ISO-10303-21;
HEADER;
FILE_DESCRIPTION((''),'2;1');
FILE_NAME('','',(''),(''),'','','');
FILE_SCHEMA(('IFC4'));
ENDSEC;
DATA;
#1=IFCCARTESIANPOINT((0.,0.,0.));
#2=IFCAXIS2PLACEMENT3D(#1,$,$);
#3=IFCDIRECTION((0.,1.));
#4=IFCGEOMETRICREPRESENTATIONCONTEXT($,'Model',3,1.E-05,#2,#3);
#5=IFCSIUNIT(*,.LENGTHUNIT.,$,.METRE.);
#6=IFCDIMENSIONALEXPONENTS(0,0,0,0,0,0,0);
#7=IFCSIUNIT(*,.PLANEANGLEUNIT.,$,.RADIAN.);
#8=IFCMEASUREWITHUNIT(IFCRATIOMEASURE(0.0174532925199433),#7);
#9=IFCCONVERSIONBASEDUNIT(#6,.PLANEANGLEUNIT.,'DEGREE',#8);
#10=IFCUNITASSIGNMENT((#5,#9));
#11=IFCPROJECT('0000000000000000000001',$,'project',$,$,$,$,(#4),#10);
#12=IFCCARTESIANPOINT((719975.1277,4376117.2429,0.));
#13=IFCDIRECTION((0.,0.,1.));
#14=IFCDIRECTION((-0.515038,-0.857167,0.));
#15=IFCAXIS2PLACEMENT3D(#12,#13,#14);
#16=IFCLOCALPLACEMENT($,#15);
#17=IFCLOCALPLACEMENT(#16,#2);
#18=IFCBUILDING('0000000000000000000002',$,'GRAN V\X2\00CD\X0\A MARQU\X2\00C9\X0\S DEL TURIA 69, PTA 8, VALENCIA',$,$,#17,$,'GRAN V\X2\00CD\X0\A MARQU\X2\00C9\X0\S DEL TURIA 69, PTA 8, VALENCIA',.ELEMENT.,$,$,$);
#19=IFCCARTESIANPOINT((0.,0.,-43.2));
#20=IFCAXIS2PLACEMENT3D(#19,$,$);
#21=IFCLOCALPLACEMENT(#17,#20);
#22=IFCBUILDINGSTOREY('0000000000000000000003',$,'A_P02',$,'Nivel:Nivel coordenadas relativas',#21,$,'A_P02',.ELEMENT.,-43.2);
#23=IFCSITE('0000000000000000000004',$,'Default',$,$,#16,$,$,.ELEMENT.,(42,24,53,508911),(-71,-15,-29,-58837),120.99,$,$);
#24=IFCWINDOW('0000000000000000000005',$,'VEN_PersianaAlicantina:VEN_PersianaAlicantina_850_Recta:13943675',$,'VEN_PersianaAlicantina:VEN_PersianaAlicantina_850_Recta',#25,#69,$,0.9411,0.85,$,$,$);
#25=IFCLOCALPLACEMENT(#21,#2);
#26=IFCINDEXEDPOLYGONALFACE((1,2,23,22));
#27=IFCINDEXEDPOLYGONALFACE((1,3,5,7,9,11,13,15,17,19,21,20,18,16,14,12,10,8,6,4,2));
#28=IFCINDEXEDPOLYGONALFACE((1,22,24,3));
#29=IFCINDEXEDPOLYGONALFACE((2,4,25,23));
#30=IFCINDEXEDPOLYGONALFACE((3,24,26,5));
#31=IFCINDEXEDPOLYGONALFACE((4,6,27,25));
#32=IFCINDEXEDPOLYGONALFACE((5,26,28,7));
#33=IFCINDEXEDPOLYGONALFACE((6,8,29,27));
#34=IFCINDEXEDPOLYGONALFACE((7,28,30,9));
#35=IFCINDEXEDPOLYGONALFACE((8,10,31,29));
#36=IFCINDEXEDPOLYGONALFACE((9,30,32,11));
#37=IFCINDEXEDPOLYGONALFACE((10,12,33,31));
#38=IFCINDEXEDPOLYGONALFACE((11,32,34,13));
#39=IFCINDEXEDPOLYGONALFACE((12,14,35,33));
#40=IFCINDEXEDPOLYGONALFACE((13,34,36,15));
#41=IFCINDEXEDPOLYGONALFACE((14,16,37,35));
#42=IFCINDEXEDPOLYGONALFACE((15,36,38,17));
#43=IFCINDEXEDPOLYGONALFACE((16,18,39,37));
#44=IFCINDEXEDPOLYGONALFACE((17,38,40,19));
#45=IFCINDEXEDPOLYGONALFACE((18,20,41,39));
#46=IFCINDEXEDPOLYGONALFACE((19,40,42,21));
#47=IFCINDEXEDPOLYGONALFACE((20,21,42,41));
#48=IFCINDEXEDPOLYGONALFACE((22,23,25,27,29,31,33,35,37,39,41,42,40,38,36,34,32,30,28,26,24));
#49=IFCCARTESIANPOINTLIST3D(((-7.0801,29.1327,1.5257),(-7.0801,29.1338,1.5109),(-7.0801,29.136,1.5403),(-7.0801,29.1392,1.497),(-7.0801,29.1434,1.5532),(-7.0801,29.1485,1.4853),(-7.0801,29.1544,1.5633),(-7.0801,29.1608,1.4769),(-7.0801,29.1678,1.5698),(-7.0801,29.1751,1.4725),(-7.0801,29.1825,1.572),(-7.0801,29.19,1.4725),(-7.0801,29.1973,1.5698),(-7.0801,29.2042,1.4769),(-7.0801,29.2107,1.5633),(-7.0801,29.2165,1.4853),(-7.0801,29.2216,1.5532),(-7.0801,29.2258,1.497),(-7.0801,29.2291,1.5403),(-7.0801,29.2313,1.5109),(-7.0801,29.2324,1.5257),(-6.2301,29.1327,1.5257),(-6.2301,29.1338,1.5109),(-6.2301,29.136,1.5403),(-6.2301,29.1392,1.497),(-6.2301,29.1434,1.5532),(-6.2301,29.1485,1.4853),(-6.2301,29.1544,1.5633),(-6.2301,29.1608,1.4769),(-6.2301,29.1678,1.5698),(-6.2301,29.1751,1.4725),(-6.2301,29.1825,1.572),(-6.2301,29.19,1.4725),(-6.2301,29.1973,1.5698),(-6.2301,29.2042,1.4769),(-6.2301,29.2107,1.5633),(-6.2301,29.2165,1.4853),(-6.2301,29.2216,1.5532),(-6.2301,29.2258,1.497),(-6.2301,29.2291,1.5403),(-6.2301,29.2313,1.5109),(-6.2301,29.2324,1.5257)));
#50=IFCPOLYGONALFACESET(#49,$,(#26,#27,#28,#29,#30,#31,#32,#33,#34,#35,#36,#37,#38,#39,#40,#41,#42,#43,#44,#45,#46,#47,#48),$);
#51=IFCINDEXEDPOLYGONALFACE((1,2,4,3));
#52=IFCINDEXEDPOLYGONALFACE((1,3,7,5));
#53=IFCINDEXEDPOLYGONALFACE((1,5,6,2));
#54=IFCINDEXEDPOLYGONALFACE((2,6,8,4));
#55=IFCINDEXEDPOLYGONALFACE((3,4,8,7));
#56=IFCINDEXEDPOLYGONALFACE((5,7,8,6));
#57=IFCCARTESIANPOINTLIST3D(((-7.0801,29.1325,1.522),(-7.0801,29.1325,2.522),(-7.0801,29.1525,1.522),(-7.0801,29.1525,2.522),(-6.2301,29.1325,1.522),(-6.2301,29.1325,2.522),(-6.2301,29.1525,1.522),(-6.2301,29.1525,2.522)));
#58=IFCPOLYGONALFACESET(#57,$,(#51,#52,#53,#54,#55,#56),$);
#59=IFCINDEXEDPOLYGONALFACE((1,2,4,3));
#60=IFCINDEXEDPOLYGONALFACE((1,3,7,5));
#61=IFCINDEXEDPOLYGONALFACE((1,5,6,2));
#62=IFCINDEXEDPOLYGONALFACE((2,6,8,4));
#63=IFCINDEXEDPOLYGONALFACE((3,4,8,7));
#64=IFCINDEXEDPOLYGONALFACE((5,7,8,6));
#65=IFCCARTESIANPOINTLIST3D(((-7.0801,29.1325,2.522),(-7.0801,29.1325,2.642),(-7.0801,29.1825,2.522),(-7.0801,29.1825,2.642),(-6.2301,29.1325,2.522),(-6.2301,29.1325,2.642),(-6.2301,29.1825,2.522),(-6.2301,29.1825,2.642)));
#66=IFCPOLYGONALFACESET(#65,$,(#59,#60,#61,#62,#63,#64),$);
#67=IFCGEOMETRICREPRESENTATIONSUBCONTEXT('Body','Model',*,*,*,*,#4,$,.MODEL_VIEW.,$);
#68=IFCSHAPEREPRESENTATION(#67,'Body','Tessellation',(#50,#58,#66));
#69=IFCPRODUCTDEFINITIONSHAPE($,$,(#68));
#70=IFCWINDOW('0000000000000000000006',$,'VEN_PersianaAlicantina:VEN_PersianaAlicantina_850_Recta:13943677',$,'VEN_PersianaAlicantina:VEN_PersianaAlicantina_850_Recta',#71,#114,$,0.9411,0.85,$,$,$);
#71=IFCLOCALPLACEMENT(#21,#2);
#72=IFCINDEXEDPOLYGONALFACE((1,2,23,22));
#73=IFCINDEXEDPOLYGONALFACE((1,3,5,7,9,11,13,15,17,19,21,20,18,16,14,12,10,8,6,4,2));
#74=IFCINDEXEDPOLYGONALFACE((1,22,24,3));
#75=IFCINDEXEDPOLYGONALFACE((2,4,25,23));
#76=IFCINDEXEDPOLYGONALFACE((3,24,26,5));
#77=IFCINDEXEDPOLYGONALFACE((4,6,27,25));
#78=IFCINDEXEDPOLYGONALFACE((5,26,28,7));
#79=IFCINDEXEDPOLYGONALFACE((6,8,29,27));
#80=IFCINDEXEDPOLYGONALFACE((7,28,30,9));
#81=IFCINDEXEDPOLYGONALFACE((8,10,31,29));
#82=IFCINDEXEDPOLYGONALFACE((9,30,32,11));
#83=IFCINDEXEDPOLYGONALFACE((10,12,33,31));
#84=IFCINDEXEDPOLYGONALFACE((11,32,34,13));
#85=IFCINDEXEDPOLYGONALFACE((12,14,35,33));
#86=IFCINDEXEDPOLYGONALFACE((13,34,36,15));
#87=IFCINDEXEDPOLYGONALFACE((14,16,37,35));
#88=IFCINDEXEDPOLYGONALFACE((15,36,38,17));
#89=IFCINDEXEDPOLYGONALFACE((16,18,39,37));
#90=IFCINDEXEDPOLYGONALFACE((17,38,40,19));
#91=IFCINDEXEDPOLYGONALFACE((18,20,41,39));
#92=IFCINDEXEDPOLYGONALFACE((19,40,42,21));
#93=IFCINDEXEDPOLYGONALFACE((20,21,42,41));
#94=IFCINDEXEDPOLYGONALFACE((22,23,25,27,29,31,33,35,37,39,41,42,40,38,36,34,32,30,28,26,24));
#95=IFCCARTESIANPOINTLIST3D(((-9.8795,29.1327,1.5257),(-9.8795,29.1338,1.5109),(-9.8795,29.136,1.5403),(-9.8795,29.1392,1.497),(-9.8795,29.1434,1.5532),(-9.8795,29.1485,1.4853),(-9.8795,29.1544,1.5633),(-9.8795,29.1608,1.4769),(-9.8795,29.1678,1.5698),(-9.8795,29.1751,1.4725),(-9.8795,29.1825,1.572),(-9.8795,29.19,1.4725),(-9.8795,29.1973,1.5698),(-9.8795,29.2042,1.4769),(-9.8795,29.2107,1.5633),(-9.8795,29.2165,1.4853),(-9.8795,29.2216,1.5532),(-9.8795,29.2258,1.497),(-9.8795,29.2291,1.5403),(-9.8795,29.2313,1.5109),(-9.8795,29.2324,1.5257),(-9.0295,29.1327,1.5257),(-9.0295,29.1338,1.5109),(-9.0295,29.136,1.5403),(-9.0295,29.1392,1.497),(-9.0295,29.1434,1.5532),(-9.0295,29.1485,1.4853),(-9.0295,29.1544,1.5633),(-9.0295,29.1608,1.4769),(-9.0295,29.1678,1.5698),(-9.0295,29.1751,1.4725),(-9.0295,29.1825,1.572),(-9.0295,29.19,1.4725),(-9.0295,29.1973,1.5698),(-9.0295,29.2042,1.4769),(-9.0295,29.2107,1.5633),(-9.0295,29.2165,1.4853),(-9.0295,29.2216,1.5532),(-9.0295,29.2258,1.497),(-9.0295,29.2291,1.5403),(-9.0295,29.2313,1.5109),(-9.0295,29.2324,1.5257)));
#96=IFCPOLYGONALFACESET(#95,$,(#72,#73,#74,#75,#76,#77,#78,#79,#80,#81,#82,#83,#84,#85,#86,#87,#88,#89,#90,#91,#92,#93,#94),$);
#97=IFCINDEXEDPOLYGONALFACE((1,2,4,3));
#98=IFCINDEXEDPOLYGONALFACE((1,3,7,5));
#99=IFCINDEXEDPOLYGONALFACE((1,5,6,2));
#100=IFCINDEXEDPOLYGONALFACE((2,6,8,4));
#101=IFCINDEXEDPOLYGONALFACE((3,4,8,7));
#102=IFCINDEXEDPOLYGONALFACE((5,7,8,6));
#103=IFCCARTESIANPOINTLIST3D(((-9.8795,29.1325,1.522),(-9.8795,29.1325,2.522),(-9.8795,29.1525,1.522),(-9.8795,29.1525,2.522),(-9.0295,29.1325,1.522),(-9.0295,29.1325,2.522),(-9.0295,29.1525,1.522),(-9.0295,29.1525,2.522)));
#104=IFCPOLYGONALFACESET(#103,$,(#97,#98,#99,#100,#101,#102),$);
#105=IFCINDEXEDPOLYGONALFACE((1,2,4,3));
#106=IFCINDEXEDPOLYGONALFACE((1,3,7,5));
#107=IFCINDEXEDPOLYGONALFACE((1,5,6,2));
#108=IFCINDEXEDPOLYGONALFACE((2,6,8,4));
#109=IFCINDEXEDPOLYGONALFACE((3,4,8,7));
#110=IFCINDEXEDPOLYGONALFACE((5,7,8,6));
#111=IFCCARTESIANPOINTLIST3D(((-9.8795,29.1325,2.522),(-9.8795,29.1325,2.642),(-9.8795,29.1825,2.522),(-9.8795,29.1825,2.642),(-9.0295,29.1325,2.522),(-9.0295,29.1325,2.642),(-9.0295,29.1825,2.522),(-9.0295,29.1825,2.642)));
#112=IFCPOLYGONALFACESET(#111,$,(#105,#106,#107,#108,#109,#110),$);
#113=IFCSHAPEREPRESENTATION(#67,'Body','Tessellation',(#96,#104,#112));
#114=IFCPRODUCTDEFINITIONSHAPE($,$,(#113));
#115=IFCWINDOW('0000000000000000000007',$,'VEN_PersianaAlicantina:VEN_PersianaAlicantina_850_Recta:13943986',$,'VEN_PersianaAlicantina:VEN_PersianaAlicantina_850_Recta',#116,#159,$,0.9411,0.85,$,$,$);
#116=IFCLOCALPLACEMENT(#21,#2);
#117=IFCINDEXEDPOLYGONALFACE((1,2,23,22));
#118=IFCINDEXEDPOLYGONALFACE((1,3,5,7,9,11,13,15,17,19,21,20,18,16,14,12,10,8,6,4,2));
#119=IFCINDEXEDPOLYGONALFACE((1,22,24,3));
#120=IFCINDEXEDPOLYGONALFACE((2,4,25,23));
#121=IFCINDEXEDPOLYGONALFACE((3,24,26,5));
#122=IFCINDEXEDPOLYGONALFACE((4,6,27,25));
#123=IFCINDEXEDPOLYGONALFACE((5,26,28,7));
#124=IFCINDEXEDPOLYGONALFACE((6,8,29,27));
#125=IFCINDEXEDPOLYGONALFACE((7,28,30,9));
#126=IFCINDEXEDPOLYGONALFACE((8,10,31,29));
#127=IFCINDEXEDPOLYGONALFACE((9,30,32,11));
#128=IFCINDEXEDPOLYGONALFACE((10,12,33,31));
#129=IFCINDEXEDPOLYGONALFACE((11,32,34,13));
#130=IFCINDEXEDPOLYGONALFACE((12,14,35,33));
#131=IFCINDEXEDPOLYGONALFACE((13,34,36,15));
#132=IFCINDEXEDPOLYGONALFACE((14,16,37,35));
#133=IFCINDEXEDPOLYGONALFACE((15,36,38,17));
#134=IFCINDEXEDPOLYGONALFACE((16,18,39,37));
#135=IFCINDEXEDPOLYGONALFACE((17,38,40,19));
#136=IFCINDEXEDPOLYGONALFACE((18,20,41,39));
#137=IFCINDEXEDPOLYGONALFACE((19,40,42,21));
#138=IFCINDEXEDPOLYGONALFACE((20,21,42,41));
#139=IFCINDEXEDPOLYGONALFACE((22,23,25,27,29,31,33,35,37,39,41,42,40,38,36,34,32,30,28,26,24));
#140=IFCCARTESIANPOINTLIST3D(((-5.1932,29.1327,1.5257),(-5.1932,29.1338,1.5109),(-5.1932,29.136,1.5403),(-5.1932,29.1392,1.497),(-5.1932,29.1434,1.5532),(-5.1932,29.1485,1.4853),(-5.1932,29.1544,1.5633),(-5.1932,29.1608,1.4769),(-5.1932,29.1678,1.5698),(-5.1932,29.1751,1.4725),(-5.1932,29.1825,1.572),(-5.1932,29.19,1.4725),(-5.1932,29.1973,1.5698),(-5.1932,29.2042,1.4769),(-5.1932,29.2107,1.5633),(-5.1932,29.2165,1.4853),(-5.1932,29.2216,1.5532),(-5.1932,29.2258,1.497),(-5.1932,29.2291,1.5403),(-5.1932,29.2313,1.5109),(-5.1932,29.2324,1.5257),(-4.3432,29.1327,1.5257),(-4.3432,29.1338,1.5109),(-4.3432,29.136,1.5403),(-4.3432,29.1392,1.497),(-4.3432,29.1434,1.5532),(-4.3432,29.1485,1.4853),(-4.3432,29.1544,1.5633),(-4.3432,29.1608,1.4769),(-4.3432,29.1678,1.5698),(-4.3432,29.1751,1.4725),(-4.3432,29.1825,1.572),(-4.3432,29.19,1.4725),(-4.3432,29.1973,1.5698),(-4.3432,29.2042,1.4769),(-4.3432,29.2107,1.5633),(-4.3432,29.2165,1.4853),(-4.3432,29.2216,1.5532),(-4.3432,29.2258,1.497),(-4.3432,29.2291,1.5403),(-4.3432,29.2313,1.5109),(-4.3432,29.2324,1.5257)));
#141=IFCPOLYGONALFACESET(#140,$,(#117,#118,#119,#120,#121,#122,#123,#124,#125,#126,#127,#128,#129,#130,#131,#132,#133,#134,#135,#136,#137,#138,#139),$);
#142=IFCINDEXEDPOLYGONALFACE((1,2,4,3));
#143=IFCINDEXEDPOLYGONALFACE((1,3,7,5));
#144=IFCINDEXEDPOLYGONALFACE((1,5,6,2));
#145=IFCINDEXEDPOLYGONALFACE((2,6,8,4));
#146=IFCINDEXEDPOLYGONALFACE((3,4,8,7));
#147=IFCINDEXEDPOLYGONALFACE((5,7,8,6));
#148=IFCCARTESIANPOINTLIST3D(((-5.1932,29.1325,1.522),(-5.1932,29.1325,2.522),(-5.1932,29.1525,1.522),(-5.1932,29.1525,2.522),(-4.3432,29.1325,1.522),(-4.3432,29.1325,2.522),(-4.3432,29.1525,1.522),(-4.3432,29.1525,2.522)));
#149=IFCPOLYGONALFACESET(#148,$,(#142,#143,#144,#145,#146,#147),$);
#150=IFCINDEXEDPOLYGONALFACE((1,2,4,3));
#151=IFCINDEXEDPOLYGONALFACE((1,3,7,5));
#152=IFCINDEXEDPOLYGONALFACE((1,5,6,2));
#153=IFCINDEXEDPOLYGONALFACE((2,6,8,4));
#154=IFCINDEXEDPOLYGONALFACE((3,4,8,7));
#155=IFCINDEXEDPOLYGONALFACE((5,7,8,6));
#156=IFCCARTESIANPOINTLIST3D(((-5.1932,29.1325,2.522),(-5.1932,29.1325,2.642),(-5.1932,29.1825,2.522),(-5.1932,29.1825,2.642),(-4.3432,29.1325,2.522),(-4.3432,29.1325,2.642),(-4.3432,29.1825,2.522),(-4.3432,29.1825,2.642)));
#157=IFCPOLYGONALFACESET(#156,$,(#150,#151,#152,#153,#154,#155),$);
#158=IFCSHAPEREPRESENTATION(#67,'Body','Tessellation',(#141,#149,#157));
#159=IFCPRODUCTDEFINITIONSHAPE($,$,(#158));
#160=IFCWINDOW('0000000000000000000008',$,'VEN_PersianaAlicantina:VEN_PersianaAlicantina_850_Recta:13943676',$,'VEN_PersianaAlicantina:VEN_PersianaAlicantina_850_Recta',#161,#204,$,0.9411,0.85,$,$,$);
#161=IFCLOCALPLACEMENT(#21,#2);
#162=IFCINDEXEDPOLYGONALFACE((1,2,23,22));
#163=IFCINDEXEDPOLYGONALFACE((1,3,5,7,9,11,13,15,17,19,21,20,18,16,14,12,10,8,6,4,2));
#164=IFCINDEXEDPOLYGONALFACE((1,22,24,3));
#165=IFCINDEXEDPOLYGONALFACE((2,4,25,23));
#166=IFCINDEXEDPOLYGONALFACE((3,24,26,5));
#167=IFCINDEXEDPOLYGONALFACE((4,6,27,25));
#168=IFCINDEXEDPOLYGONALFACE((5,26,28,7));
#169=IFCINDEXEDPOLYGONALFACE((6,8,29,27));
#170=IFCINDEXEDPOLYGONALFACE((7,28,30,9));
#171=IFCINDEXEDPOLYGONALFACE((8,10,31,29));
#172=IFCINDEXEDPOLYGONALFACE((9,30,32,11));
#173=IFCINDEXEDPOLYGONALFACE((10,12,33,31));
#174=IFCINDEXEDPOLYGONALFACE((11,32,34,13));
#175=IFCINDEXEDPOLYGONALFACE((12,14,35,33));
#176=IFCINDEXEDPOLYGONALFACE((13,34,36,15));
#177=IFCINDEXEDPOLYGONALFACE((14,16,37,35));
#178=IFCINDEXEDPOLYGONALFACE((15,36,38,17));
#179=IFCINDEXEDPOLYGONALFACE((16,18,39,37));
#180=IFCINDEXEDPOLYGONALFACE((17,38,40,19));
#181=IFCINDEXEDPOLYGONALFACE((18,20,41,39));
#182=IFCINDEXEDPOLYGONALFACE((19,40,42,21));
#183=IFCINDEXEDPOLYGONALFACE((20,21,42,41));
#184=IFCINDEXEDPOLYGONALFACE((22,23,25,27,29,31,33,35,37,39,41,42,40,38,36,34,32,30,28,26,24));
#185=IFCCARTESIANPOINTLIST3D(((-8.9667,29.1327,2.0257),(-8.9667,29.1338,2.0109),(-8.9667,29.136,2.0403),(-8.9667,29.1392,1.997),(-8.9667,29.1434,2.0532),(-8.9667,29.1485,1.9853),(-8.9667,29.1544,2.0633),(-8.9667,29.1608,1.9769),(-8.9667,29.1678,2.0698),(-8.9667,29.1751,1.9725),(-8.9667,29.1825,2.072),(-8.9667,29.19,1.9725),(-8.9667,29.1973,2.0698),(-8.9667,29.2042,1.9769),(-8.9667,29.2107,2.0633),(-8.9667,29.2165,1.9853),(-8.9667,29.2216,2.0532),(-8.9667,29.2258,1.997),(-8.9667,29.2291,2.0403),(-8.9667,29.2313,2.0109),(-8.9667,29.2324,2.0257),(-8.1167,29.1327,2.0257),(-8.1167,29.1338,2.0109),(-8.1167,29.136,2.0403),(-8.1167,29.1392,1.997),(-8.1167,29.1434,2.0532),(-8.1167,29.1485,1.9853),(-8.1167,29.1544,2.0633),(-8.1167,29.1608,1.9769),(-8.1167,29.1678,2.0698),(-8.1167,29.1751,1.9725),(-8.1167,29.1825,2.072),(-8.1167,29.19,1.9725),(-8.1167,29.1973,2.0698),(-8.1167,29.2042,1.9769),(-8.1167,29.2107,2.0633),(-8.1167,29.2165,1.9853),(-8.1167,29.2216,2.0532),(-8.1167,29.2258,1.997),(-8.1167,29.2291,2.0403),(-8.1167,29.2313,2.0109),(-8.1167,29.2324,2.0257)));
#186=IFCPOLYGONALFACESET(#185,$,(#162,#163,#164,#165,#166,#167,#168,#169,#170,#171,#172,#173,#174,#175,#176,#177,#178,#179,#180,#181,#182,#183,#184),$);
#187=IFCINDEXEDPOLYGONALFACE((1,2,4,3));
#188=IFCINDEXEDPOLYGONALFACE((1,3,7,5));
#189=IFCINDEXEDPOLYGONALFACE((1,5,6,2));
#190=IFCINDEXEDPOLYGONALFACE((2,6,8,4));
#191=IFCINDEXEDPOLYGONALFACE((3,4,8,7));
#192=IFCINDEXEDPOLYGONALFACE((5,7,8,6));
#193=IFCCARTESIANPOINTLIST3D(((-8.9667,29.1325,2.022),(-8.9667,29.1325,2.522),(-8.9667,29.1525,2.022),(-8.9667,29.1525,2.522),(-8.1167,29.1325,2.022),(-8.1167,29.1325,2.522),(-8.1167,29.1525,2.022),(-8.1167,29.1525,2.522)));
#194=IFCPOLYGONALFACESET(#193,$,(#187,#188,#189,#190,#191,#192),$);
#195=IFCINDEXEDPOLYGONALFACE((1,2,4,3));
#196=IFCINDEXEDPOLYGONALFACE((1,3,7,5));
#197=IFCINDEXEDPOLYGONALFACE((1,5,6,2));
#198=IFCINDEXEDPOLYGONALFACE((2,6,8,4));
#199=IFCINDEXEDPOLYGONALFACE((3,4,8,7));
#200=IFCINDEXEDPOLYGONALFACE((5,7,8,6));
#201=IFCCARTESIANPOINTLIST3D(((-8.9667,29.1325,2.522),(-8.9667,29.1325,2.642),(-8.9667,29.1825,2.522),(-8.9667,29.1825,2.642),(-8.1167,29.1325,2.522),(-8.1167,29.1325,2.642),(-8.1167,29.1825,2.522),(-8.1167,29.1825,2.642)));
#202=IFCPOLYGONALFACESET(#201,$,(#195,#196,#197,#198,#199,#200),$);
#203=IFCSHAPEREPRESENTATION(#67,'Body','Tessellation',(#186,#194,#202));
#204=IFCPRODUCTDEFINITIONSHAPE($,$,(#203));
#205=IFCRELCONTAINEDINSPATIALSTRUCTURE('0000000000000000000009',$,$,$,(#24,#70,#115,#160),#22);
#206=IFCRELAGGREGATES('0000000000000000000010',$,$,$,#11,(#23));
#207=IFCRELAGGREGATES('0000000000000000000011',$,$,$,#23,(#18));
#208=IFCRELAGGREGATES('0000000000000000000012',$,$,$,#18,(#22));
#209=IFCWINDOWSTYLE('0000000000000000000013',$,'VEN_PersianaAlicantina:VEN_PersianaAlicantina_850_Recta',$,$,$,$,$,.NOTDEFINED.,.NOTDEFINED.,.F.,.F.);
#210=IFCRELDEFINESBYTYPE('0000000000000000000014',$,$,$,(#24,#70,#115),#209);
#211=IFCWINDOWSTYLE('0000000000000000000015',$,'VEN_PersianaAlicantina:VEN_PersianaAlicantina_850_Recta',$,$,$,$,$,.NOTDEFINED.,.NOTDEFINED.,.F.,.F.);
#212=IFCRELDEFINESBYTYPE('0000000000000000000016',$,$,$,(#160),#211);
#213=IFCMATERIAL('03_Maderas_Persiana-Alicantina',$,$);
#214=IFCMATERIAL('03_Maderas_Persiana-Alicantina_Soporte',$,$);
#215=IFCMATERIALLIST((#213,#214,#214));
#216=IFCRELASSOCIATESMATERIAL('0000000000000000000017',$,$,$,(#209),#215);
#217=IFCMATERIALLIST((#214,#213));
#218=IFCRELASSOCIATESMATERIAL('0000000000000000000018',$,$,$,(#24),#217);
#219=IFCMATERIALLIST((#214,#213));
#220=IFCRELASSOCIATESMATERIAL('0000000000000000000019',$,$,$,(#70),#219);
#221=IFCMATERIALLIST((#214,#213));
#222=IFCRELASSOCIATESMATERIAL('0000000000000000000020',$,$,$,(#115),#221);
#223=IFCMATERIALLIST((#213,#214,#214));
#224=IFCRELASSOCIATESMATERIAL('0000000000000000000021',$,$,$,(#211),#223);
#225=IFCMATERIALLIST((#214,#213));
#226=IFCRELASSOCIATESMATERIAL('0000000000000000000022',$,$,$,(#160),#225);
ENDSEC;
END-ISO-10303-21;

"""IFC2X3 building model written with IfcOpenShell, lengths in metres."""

from ifc_helpers import new_model, entity, si_unit, converted_unit, direction, frame, frame_2d, origin, origin_2d_with_axis, place, context, subcontext, project, spatial, rectangle, circle, extrude, source, transform, mapped, material, material_list, type_object, type_shapes, element, save


model = new_model("IFC2X3")

# Units and contexts
model_context = context("Model", 3, precision=1e-05, world=origin(), true_north=direction((0.0, 1.0)))
body_context = subcontext(model_context, "Body", "Model", "MODEL_VIEW")
ifc_project = project(units=[si_unit("LENGTHUNIT", "METRE"), converted_unit("PLANEANGLEUNIT", "DEGREE", entity("IfcRatioMeasure", 0.0174532925199433), si_unit("PLANEANGLEUNIT", "RADIAN"), dimensions=[0, 0, 0, 0, 0, 0, 0])], contexts=[model_context])

# Site, building, storey
site_placement = place(None, frame((719975.1277, 4376117.2429, 0.0), z_axis=(0.0, 0.0, 1.0), x_axis=(-0.515038, -0.857167, 0.0)))
site = spatial("IfcSite", under=ifc_project, at=site_placement, Name="Default", CompositionType="ELEMENT", RefLatitude=(42, 24, 53, 508911), RefLongitude=(-71, -15, -29, -58837), RefElevation=120.99)
building_placement = place(site_placement, origin())
building = spatial("IfcBuilding", under=site, at=building_placement, Name="GRAN VÍA MARQUÉS DEL TURIA 69, PTA 8, VALENCIA", LongName="GRAN VÍA MARQUÉS DEL TURIA 69, PTA 8, VALENCIA", CompositionType="ELEMENT")
storey_placement = place(building_placement, frame((0.0, 0.0, -43.2)))
storey = spatial("IfcBuildingStorey", under=building, at=storey_placement, Name="A_P02", ObjectType="Nivel:Nivel coordenadas relativas", LongName="A_P02", CompositionType="ELEMENT", Elevation=-43.2)

# Windows
ifc_material_1 = material(Name="03_Maderas_Persiana-Alicantina_Soporte")
ifc_material_2 = material(Name="03_Maderas_Persiana-Alicantina")
ifc_material_list_1 = material_list([ifc_material_1, ifc_material_2])
ifc_material_list_2 = material_list([ifc_material_2, ifc_material_1, ifc_material_1])
window_style_1 = type_object("IfcWindowStyle", Name="VEN_PersianaAlicantina:VEN_PersianaAlicantina_850_Recta", ConstructionType="NOTDEFINED", OperationType="NOTDEFINED", ParameterTakesPrecedence=False, Sizeable=False, material=ifc_material_list_2)
shared_shape_1 = source(origin(), body_context, "Body", "SweptSolid", [
    extrude(circle(Radius=0.05, at=frame_2d((0.0, 0.0), x_axis=(1.0, 0.0))), frame((-0.425, -0.5392, 0.05), z_axis=(1.0, 0.0, 0.0), x_axis=(0.0, 1.0, 0.0)), (0.0, 0.0, 1.0), 0.85),
    extrude(rectangle(XDim=0.85, YDim=1.0, at=frame_2d((0.0, 0.0), x_axis=(1.0, 0.0))), frame((0.0, -0.0392, 0.0), z_axis=(0.0, 0.0, 1.0), x_axis=(-1.0, 0.0, 0.0)), (0.0, 0.0, 1.0), 0.02),
    extrude(rectangle(XDim=0.85, YDim=0.12, at=frame_2d((0.0, 0.0), x_axis=(1.0, 0.0))), frame((0.0, 0.5208, 0.0), z_axis=(0.0, 0.0, 1.0), x_axis=(-1.0, 0.0, 0.0)), (0.0, 0.0, 1.0), 0.05),
])
type_shapes(window_style_1, [shared_shape_1])
window_1_placement = place(storey_placement, frame((-6.6551, 29.1325, 2.0612), z_axis=(0.0, 1.0, 0.0), x_axis=(-1.0, 0.0, 0.0)))
element("IfcWindow", 1, at=window_1_placement, inside=storey, type_object=window_style_1, material=ifc_material_list_1, Name="VEN_PersianaAlicantina:VEN_PersianaAlicantina_850_Recta:13943675", ObjectType="VEN_PersianaAlicantina:VEN_PersianaAlicantina_850_Recta", OverallHeight=0.9411, OverallWidth=0.85, context=body_context, shape_type="MappedRepresentation", body=[
    mapped(shared_shape_1, transform((0.0, 0.0, 0.0), scale=1.0)),
])
ifc_material_list_3 = material_list([ifc_material_1, ifc_material_2])
window_2_placement = place(storey_placement, frame((-9.4545, 29.1325, 2.0612), z_axis=(0.0, 1.0, 0.0), x_axis=(-1.0, 0.0, 0.0)))
element("IfcWindow", 2, at=window_2_placement, inside=storey, type_object=window_style_1, material=ifc_material_list_3, Name="VEN_PersianaAlicantina:VEN_PersianaAlicantina_850_Recta:13943677", ObjectType="VEN_PersianaAlicantina:VEN_PersianaAlicantina_850_Recta", OverallHeight=0.9411, OverallWidth=0.85, context=body_context, shape_type="MappedRepresentation", body=[
    mapped(shared_shape_1, transform((0.0, 0.0, 0.0), scale=1.0)),
])
ifc_material_list_4 = material_list([ifc_material_1, ifc_material_2])
window_3_placement = place(storey_placement, frame((-4.7682, 29.1325, 2.0612), z_axis=(0.0, 1.0, 0.0), x_axis=(-1.0, 0.0, 0.0)))
element("IfcWindow", 3, at=window_3_placement, inside=storey, type_object=window_style_1, material=ifc_material_list_4, Name="VEN_PersianaAlicantina:VEN_PersianaAlicantina_850_Recta:13943986", ObjectType="VEN_PersianaAlicantina:VEN_PersianaAlicantina_850_Recta", OverallHeight=0.9411, OverallWidth=0.85, context=body_context, shape_type="MappedRepresentation", body=[
    mapped(shared_shape_1, transform((0.0, 0.0, 0.0), scale=1.0)),
])
ifc_material_list_5 = material_list([ifc_material_1, ifc_material_2])
ifc_material_list_6 = material_list([ifc_material_2, ifc_material_1, ifc_material_1])
window_style_2 = type_object("IfcWindowStyle", Name="VEN_PersianaAlicantina:VEN_PersianaAlicantina_850_Recta", ConstructionType="NOTDEFINED", OperationType="NOTDEFINED", ParameterTakesPrecedence=False, Sizeable=False, material=ifc_material_list_6)
shared_shape_2 = source(origin(), body_context, "Body", "SweptSolid", [
    extrude(circle(Radius=0.05, at=frame_2d((0.0, 0.0), x_axis=(1.0, 0.0))), frame((-0.425, -0.0392, 0.05), z_axis=(1.0, 0.0, 0.0), x_axis=(0.0, 1.0, 0.0)), (0.0, 0.0, 1.0), 0.85),
    extrude(rectangle(XDim=0.85, YDim=0.5, at=origin_2d_with_axis()), frame((0.0, 0.2108, 0.0), z_axis=(0.0, 0.0, 1.0), x_axis=(-1.0, 0.0, 0.0)), (0.0, 0.0, 1.0), 0.02),
    extrude(rectangle(XDim=0.85, YDim=0.12, at=frame_2d((0.0, 0.0), x_axis=(1.0, 0.0))), frame((0.0, 0.5208, 0.0), z_axis=(0.0, 0.0, 1.0), x_axis=(-1.0, 0.0, 0.0)), (0.0, 0.0, 1.0), 0.05),
])
type_shapes(window_style_2, [shared_shape_2])
window_4_placement = place(storey_placement, frame((-8.5417, 29.1325, 2.0612), z_axis=(0.0, 1.0, 0.0), x_axis=(-1.0, 0.0, 0.0)))
element("IfcWindow", 4, at=window_4_placement, inside=storey, type_object=window_style_2, material=ifc_material_list_5, Name="VEN_PersianaAlicantina:VEN_PersianaAlicantina_850_Recta:13943676", ObjectType="VEN_PersianaAlicantina:VEN_PersianaAlicantina_850_Recta", OverallHeight=0.9411, OverallWidth=0.85, context=body_context, shape_type="MappedRepresentation", body=[
    mapped(shared_shape_2, transform((0.0, 0.0, 0.0), scale=1.0)),
])

save(model, "model.ifc")
